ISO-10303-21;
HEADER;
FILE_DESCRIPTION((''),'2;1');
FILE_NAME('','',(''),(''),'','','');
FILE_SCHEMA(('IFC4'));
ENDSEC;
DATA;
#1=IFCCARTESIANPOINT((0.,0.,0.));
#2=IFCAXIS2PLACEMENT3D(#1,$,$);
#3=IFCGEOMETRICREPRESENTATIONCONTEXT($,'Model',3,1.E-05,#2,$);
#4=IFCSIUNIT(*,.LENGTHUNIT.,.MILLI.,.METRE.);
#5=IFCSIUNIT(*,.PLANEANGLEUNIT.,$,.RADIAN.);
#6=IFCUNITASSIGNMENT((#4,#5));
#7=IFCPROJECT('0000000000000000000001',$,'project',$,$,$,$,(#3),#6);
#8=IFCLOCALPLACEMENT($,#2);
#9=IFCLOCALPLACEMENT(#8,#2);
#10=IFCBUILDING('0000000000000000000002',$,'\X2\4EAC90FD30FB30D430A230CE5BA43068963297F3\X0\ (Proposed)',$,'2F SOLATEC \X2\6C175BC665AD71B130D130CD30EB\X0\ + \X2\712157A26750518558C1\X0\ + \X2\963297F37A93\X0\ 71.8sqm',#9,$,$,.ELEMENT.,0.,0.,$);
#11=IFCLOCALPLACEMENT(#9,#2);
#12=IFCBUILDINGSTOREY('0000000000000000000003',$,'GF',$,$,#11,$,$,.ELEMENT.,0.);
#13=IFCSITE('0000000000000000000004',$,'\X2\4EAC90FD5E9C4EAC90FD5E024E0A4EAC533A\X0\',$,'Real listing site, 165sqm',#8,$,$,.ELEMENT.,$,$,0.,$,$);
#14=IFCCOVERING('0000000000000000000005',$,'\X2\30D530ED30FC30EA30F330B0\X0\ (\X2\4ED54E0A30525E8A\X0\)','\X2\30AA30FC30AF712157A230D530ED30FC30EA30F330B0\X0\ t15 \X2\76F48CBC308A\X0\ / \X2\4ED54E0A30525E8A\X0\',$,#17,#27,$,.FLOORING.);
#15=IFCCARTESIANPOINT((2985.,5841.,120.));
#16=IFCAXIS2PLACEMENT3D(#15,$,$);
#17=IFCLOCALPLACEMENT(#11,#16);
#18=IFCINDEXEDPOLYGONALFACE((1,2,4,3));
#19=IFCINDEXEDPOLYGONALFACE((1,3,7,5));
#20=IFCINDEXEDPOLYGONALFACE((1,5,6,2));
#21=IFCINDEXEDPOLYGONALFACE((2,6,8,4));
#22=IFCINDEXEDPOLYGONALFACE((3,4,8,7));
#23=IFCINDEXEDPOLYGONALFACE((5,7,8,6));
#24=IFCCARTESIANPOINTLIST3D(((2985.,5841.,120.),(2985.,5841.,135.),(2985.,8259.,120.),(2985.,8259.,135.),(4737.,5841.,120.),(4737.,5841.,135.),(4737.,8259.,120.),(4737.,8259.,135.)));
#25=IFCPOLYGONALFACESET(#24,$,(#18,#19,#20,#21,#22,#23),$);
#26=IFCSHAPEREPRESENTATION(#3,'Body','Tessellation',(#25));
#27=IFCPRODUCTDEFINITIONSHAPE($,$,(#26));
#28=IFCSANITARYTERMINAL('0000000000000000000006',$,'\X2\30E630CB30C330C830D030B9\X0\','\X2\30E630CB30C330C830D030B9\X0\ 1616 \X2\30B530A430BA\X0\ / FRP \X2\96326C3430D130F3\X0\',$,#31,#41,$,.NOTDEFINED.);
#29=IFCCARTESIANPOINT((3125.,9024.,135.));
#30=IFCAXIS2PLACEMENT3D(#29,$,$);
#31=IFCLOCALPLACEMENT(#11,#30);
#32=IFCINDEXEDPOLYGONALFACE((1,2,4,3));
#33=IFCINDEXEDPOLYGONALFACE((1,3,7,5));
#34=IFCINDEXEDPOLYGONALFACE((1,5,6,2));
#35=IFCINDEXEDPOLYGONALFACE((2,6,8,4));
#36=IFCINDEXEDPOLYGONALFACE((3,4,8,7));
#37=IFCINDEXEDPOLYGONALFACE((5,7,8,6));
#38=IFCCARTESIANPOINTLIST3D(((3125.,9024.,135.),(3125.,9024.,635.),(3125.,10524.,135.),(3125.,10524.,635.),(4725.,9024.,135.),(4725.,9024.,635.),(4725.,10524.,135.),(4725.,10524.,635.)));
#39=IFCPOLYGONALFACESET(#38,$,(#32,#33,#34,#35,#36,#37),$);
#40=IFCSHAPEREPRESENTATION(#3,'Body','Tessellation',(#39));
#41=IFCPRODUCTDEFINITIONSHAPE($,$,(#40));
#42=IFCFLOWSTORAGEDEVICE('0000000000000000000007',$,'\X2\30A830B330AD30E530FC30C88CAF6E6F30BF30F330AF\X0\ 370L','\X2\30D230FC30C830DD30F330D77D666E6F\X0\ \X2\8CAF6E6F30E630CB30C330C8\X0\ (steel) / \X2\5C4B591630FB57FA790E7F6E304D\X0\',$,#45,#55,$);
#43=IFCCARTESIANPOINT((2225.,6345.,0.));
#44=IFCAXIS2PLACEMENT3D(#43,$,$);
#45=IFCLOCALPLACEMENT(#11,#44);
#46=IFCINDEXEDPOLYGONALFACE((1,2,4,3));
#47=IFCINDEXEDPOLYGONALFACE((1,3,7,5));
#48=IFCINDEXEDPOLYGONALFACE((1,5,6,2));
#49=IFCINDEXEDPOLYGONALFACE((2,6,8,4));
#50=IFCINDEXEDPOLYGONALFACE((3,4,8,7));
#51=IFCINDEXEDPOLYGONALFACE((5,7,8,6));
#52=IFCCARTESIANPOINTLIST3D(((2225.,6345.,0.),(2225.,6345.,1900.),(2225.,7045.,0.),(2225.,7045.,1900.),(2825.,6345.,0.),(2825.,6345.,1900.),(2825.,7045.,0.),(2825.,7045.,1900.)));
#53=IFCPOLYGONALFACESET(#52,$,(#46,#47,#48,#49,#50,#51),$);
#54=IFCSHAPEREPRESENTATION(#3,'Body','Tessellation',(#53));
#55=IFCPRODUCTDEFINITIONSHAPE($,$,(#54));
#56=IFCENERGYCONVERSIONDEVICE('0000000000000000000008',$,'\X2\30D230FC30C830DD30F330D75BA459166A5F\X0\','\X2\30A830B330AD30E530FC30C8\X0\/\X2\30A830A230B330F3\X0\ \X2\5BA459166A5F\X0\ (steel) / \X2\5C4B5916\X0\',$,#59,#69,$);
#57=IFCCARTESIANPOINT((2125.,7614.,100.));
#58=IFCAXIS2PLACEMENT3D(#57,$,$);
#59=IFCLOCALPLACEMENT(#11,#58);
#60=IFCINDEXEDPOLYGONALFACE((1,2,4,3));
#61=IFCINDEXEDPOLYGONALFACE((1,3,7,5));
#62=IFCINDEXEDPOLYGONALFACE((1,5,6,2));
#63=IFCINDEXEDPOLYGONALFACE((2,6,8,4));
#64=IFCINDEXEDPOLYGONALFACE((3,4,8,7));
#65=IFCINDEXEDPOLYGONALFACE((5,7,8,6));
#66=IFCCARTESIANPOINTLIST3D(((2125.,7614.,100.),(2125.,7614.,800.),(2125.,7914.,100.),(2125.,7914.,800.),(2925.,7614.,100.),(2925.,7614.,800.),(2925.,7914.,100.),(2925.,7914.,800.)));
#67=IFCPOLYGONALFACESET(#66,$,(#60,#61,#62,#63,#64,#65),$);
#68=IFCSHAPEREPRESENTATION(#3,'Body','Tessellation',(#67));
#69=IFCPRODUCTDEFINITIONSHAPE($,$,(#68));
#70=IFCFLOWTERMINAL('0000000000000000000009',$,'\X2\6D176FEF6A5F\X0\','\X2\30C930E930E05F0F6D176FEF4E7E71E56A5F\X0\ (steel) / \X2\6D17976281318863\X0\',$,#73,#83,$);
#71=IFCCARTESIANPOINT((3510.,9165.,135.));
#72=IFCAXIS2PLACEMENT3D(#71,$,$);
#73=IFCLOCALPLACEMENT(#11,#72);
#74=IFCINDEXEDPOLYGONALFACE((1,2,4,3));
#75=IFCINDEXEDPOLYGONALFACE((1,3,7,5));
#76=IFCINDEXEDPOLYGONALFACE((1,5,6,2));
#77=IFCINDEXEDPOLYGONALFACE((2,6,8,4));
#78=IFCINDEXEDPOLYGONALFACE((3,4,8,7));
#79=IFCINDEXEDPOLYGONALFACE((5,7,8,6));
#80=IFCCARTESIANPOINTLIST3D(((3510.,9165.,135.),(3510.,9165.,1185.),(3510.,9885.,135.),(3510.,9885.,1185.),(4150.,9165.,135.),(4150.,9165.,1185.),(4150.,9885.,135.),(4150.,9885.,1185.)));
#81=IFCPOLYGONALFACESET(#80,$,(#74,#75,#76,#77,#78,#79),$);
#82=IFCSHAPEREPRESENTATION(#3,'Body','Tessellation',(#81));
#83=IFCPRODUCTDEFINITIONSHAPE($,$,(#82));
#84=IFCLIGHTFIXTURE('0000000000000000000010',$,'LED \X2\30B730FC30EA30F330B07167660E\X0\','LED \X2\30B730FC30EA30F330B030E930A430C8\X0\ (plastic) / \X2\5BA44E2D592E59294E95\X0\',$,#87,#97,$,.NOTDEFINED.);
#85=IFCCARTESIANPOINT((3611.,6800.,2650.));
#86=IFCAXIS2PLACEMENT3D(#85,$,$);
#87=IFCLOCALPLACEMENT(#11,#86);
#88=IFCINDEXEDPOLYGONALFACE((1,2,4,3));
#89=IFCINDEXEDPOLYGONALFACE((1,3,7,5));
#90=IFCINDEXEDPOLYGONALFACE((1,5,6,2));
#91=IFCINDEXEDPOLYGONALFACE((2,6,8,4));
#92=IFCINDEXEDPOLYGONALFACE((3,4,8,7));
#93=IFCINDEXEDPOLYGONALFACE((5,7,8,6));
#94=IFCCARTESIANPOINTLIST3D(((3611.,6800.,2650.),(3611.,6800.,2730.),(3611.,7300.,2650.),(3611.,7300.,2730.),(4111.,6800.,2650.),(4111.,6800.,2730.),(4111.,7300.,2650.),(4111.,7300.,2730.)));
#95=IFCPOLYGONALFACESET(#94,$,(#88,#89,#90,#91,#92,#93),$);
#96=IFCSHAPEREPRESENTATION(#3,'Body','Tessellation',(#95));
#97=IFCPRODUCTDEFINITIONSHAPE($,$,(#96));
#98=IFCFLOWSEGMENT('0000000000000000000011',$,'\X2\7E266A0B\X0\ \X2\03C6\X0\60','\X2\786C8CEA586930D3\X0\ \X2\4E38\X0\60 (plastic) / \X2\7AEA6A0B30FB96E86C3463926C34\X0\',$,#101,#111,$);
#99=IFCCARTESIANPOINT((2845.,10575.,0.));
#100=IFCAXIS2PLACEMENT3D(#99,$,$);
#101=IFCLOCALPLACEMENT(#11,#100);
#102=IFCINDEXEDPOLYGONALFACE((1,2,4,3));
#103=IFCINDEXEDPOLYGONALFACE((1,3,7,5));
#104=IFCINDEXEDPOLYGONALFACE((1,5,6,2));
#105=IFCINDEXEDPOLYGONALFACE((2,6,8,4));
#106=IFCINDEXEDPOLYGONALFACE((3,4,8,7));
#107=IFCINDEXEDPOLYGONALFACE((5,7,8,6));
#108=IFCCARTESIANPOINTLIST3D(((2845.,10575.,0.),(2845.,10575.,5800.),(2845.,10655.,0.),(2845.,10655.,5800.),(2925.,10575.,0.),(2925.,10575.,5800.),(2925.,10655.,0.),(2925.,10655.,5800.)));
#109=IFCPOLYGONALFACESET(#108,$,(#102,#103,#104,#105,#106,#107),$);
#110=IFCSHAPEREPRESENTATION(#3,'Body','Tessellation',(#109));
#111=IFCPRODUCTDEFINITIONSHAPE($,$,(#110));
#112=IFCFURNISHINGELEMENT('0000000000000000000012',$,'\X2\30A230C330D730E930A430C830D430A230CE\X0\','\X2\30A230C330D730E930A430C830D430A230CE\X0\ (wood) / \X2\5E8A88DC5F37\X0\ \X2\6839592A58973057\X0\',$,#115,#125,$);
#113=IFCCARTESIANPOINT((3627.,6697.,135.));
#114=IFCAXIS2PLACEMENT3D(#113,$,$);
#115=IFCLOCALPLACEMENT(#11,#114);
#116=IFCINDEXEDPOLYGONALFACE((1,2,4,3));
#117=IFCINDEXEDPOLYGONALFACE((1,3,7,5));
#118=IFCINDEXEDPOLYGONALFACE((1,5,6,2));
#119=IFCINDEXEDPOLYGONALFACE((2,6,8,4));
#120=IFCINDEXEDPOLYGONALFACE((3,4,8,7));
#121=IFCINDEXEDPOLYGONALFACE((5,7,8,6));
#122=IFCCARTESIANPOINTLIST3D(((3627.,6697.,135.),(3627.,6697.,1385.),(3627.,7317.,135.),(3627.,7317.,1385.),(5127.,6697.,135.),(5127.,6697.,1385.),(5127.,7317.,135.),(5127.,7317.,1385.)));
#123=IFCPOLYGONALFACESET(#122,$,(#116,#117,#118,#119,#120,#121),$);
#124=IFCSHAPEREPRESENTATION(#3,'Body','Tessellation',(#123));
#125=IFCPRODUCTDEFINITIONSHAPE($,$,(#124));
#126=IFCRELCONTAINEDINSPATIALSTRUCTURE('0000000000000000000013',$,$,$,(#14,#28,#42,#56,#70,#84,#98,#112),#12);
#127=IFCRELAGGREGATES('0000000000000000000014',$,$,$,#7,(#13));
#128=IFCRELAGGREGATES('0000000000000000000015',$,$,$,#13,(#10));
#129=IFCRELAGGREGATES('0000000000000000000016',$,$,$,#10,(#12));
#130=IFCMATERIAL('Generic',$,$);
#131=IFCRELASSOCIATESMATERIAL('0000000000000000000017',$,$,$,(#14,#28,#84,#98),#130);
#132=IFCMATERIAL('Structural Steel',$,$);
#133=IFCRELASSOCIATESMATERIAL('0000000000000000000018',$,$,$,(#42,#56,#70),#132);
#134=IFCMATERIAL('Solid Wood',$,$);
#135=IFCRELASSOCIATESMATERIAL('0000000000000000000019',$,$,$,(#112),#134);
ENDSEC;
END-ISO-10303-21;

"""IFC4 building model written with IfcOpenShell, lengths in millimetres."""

from ifc_helpers import new_model, si_unit, frame, frame_2d, origin, place, context, project, spatial, rectangle, extrude, material, element, save


model = new_model("IFC4")

# Units and contexts
model_context = context("Model", 3, precision=1e-05, world=origin())
ifc_project = project(units=[si_unit("LENGTHUNIT", "METRE", prefix="MILLI"), si_unit("PLANEANGLEUNIT", "RADIAN")], contexts=[model_context])

# Site, building, storey
site_placement = place(None, origin())
site = spatial("IfcSite", under=ifc_project, at=site_placement, Name="京都府京都市上京区", ObjectType="Real listing site, 165sqm", CompositionType="ELEMENT", RefElevation=0.0)
building_placement = place(site_placement, origin())
building = spatial("IfcBuilding", under=site, at=building_placement, Name="京都・ピアノ室と防音 (Proposed)", ObjectType="2F SOLATEC 気密断熱パネル + 無垢材内壁 + 防音窓 71.8sqm", CompositionType="ELEMENT", ElevationOfRefHeight=0.0, ElevationOfTerrain=0.0)
storey_placement = place(building_placement, origin())
storey = spatial("IfcBuildingStorey", under=building, at=storey_placement, Name="GF", CompositionType="ELEMENT", Elevation=0.0)

# Shared definitions
ifc_material_1 = material(Name="Solid Wood")

# Covering
ifc_material_2 = material(Name="Generic")
covering_1_placement = place(storey_placement, frame((2985.0, 5841.0, 120.0)))
element("IfcCovering", 1, at=covering_1_placement, inside=storey, material=ifc_material_2, Name="フローリング (仕上げ床)", Description="オーク無垢フローリング t15 直貼り / 仕上げ床", PredefinedType="FLOORING", context=model_context, shape_type="SweptSolid", body=[
    extrude(rectangle(XDim=1752.0, YDim=2418.0, at=frame_2d((876.0, 1209.0))), frame((2985.0, 5841.0, 120.0)), (0.0, 0.0, 1.0), 15.0),
])

# Sanitary terminal
sanitary_terminal_placement = place(storey_placement, frame((3125.0, 9024.0, 135.0)))
element("IfcSanitaryTerminal", 2, at=sanitary_terminal_placement, inside=storey, material=ifc_material_2, Name="ユニットバス", Description="ユニットバス 1616 サイズ / FRP 防水パン", PredefinedType="NOTDEFINED", context=model_context, shape_type="SweptSolid", body=[
    extrude(rectangle(XDim=1600.0, YDim=1500.0, at=frame_2d((800.0, 750.0))), frame((3125.0, 9024.0, 135.0)), (0.0, 0.0, 1.0), 500.0),
])

# Flow storage device
ifc_material_3 = material(Name="Structural Steel")
flow_storage_device_placement = place(storey_placement, frame((2225.0, 6345.0, 0.0)))
element("IfcFlowStorageDevice", 3, at=flow_storage_device_placement, inside=storey, material=ifc_material_3, Name="エコキュート貯湯タンク 370L", Description="ヒートポンプ給湯 貯湯ユニット (steel) / 屋外・基礎置き", context=model_context, shape_type="SweptSolid", body=[
    extrude(rectangle(XDim=600.0, YDim=700.0, at=frame_2d((300.0, 350.0))), frame((2225.0, 6345.0, 0.0)), (0.0, 0.0, 1.0), 1900.0),
])

# Energy conversion device
energy_conversion_device_placement = place(storey_placement, frame((2125.0, 7614.0, 100.0)))
element("IfcEnergyConversionDevice", 4, at=energy_conversion_device_placement, inside=storey, material=ifc_material_3, Name="ヒートポンプ室外機", Description="エコキュート/エアコン 室外機 (steel) / 屋外", context=model_context, shape_type="SweptSolid", body=[
    extrude(rectangle(XDim=800.0, YDim=300.0, at=frame_2d((400.0, 150.0))), frame((2125.0, 7614.0, 100.0)), (0.0, 0.0, 1.0), 700.0),
])

# Flow terminal
flow_terminal_placement = place(storey_placement, frame((3510.0, 9165.0, 135.0)))
element("IfcFlowTerminal", 5, at=flow_terminal_placement, inside=storey, material=ifc_material_3, Name="洗濯機", Description="ドラム式洗濯乾燥機 (steel) / 洗面脱衣", context=model_context, shape_type="SweptSolid", body=[
    extrude(rectangle(XDim=640.0, YDim=720.0, at=frame_2d((320.0, 360.0))), frame((3510.0, 9165.0, 135.0)), (0.0, 0.0, 1.0), 1050.0),
])

# Light fixture
light_fixture_placement = place(storey_placement, frame((3611.0, 6800.0, 2650.0)))
element("IfcLightFixture", 6, at=light_fixture_placement, inside=storey, material=ifc_material_2, Name="LED シーリング照明", Description="LED シーリングライト (plastic) / 室中央天井", PredefinedType="NOTDEFINED", context=model_context, shape_type="SweptSolid", body=[
    extrude(rectangle(XDim=500.0, YDim=500.0, at=frame_2d((250.0, 250.0))), frame((3611.0, 6800.0, 2650.0)), (0.0, 0.0, 1.0), 80.0),
])

# Flow segment
flow_segment_placement = place(storey_placement, frame((2845.0, 10575.0, 0.0)))
element("IfcFlowSegment", 7, at=flow_segment_placement, inside=storey, material=ifc_material_2, Name="縦樋 φ60", Description="硬質塩ビ 丸60 (plastic) / 竪樋・雨水排水", context=model_context, shape_type="SweptSolid", body=[
    extrude(rectangle(XDim=80.0, YDim=80.0, at=frame_2d((40.0, 40.0))), frame((2845.0, 10575.0, 0.0)), (0.0, 0.0, 1.0), 5800.0),
])

# Furnishing element
furnishing_placement = place(storey_placement, frame((3627.0, 6697.0, 135.0)))
element("IfcFurnishingElement", 8, at=furnishing_placement, inside=storey, material=ifc_material_1, Name="アップライトピアノ", Description="アップライトピアノ (wood) / 床補強 根太増し", context=model_context, shape_type="SweptSolid", body=[
    extrude(rectangle(XDim=1500.0, YDim=620.0, at=frame_2d((750.0, 310.0))), frame((3627.0, 6697.0, 135.0)), (0.0, 0.0, 1.0), 1250.0),
])

save(model, "model.ifc")
